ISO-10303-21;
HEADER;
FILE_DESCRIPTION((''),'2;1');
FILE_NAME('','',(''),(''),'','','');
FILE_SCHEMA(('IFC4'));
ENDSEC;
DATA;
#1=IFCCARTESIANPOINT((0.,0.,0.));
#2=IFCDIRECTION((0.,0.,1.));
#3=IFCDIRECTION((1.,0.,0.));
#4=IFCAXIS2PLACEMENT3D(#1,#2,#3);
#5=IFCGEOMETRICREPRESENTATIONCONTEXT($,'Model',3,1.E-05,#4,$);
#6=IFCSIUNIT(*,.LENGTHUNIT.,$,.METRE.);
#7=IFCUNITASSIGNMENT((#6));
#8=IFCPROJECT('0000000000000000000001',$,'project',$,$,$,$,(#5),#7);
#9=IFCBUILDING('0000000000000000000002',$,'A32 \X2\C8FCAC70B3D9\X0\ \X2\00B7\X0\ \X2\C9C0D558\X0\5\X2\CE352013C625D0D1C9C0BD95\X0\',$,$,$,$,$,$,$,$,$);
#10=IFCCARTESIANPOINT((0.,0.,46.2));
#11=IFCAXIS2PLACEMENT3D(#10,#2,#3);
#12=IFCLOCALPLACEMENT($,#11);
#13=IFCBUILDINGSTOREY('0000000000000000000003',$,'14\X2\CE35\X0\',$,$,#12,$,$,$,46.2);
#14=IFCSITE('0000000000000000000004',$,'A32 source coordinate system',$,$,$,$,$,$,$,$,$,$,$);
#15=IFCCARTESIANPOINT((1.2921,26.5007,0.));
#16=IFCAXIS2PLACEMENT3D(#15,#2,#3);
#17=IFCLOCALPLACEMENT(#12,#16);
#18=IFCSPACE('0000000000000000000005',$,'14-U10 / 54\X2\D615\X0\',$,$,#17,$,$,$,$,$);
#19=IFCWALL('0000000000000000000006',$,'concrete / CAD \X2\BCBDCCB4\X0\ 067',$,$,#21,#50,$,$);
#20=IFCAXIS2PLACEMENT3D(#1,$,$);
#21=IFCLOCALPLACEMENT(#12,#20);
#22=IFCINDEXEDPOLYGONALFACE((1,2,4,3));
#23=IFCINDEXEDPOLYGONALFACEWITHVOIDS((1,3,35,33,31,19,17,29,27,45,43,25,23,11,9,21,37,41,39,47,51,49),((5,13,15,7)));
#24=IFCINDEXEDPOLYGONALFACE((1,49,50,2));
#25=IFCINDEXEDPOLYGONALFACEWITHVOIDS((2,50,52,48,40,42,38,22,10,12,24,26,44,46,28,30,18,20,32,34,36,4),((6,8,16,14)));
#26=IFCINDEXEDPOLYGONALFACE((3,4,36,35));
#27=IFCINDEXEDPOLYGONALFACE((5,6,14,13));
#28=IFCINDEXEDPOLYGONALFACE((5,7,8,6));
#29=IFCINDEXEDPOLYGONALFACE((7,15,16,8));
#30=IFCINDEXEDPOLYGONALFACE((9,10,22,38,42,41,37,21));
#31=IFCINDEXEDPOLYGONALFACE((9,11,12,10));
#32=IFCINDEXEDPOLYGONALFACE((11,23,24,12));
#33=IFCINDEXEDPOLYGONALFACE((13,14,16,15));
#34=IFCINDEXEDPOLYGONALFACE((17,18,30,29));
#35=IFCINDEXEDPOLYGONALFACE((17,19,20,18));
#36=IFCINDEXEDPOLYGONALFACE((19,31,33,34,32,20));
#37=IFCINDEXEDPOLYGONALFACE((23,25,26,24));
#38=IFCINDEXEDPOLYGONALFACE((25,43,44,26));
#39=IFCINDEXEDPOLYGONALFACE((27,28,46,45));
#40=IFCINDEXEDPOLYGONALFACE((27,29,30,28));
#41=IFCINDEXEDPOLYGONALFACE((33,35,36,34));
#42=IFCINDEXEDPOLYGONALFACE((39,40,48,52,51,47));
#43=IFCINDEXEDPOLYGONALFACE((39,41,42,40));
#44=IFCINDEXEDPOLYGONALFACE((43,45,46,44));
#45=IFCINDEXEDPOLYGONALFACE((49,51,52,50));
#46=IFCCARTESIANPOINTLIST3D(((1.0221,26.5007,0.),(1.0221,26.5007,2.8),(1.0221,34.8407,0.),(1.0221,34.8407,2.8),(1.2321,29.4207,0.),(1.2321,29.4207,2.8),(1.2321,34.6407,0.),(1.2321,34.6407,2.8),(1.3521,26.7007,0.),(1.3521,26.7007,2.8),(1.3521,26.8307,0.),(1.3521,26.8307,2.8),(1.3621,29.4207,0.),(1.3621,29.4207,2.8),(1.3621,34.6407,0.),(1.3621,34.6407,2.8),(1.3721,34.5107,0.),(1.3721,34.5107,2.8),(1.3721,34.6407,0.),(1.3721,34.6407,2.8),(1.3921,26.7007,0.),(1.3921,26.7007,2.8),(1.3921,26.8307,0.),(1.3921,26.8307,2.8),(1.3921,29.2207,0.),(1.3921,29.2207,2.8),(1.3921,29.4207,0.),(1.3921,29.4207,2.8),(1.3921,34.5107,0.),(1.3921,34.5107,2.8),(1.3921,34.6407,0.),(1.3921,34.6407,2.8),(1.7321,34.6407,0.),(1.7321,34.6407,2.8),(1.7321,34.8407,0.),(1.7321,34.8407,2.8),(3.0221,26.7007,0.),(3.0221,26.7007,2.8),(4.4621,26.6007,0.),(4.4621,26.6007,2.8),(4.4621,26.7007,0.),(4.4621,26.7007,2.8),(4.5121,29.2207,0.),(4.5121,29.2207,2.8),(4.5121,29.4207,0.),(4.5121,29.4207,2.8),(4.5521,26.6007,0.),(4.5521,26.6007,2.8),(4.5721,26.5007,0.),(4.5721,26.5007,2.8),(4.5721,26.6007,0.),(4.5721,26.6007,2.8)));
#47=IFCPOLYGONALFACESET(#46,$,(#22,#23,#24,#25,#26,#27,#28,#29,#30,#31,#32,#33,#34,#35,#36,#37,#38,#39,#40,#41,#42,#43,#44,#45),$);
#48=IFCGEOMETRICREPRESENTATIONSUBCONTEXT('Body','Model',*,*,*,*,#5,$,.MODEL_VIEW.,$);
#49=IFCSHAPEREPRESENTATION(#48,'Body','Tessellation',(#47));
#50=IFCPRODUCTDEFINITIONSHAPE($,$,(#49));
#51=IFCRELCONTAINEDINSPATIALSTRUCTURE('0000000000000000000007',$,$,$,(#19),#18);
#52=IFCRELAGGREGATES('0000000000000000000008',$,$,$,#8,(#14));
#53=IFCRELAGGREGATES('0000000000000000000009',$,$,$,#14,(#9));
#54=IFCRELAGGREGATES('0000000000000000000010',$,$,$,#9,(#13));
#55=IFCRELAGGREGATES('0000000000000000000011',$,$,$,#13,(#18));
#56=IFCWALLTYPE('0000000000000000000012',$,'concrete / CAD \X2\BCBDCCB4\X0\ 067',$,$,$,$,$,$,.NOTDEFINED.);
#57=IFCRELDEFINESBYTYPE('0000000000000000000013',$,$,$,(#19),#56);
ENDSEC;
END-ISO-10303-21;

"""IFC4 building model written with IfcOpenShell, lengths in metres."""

from ifc_helpers import new_model, si_unit, frame, origin, origin_with_axes, place, context, subcontext, project, spatial, polyline, outline, extrude, source, transform, mapped, type_object, type_shapes, element, save


model = new_model("IFC4")

# Units and contexts
model_context = context("Model", 3, precision=1e-05, world=origin_with_axes())
body_context = subcontext(model_context, "Body", "Model", "MODEL_VIEW")
ifc_project = project(units=[si_unit("LENGTHUNIT", "METRE")], contexts=[model_context])

# Site, building, storey, space
site = spatial("IfcSite", under=ifc_project, Name="A32 source coordinate system")
building = spatial("IfcBuilding", under=site, Name="A32 주거동 · 지하5층–옥탑지붕")
storey_placement = place(None, frame((0.0, 0.0, 46.2), z_axis=(0.0, 0.0, 1.0), x_axis=(1.0, 0.0, 0.0)))
storey = spatial("IfcBuildingStorey", under=building, at=storey_placement, Name="14층", Elevation=46.2)
space_placement = place(storey_placement, frame((1.2921, 26.5007, 0.0), z_axis=(0.0, 0.0, 1.0), x_axis=(1.0, 0.0, 0.0)))
space = spatial("IfcSpace", under=storey, at=space_placement, Name="14-U10 / 54형")

# Wall
wall_type_1 = type_object("IfcWallType", Name="concrete / CAD 벽체 067", PredefinedType="NOTDEFINED")
shared_shape_1 = source(origin(), body_context, "Body", "SweptSolid", [
    extrude(outline(polyline([(0.1, 0.2), (1.73, 0.2), (3.17, 0.2), (3.17, 0.1), (3.26, 0.1), (3.28, 0.1), (3.28, 0.0), (-0.27, 0.0), (-0.27, 8.34), (0.44, 8.34), (0.44, 8.14), (0.1, 8.14), (0.08, 8.14), (0.08, 8.01), (0.1, 8.01), (0.1, 2.92), (3.22, 2.92), (3.22, 2.72), (0.1, 2.72), (0.1, 0.33), (0.06, 0.33), (0.06, 0.2), (0.1, 0.2)]), holes=[polyline([(-0.06, 8.14), (-0.06, 2.92), (0.07, 2.92), (0.07, 8.14), (-0.06, 8.14)])]), origin(), (0.0, 0.0, 1.0), 2.8),
])
type_shapes(wall_type_1, [shared_shape_1])
wall_1_placement = place(space_placement, origin_with_axes())
element("IfcWall", 1, at=wall_1_placement, inside=space, type_object=wall_type_1, Name="concrete / CAD 벽체 067", context=body_context, shape_type="MappedRepresentation", body=[
    mapped(shared_shape_1, transform((0.0, 0.0, 0.0), scale=1.0)),
])

save(model, "model.ifc")
